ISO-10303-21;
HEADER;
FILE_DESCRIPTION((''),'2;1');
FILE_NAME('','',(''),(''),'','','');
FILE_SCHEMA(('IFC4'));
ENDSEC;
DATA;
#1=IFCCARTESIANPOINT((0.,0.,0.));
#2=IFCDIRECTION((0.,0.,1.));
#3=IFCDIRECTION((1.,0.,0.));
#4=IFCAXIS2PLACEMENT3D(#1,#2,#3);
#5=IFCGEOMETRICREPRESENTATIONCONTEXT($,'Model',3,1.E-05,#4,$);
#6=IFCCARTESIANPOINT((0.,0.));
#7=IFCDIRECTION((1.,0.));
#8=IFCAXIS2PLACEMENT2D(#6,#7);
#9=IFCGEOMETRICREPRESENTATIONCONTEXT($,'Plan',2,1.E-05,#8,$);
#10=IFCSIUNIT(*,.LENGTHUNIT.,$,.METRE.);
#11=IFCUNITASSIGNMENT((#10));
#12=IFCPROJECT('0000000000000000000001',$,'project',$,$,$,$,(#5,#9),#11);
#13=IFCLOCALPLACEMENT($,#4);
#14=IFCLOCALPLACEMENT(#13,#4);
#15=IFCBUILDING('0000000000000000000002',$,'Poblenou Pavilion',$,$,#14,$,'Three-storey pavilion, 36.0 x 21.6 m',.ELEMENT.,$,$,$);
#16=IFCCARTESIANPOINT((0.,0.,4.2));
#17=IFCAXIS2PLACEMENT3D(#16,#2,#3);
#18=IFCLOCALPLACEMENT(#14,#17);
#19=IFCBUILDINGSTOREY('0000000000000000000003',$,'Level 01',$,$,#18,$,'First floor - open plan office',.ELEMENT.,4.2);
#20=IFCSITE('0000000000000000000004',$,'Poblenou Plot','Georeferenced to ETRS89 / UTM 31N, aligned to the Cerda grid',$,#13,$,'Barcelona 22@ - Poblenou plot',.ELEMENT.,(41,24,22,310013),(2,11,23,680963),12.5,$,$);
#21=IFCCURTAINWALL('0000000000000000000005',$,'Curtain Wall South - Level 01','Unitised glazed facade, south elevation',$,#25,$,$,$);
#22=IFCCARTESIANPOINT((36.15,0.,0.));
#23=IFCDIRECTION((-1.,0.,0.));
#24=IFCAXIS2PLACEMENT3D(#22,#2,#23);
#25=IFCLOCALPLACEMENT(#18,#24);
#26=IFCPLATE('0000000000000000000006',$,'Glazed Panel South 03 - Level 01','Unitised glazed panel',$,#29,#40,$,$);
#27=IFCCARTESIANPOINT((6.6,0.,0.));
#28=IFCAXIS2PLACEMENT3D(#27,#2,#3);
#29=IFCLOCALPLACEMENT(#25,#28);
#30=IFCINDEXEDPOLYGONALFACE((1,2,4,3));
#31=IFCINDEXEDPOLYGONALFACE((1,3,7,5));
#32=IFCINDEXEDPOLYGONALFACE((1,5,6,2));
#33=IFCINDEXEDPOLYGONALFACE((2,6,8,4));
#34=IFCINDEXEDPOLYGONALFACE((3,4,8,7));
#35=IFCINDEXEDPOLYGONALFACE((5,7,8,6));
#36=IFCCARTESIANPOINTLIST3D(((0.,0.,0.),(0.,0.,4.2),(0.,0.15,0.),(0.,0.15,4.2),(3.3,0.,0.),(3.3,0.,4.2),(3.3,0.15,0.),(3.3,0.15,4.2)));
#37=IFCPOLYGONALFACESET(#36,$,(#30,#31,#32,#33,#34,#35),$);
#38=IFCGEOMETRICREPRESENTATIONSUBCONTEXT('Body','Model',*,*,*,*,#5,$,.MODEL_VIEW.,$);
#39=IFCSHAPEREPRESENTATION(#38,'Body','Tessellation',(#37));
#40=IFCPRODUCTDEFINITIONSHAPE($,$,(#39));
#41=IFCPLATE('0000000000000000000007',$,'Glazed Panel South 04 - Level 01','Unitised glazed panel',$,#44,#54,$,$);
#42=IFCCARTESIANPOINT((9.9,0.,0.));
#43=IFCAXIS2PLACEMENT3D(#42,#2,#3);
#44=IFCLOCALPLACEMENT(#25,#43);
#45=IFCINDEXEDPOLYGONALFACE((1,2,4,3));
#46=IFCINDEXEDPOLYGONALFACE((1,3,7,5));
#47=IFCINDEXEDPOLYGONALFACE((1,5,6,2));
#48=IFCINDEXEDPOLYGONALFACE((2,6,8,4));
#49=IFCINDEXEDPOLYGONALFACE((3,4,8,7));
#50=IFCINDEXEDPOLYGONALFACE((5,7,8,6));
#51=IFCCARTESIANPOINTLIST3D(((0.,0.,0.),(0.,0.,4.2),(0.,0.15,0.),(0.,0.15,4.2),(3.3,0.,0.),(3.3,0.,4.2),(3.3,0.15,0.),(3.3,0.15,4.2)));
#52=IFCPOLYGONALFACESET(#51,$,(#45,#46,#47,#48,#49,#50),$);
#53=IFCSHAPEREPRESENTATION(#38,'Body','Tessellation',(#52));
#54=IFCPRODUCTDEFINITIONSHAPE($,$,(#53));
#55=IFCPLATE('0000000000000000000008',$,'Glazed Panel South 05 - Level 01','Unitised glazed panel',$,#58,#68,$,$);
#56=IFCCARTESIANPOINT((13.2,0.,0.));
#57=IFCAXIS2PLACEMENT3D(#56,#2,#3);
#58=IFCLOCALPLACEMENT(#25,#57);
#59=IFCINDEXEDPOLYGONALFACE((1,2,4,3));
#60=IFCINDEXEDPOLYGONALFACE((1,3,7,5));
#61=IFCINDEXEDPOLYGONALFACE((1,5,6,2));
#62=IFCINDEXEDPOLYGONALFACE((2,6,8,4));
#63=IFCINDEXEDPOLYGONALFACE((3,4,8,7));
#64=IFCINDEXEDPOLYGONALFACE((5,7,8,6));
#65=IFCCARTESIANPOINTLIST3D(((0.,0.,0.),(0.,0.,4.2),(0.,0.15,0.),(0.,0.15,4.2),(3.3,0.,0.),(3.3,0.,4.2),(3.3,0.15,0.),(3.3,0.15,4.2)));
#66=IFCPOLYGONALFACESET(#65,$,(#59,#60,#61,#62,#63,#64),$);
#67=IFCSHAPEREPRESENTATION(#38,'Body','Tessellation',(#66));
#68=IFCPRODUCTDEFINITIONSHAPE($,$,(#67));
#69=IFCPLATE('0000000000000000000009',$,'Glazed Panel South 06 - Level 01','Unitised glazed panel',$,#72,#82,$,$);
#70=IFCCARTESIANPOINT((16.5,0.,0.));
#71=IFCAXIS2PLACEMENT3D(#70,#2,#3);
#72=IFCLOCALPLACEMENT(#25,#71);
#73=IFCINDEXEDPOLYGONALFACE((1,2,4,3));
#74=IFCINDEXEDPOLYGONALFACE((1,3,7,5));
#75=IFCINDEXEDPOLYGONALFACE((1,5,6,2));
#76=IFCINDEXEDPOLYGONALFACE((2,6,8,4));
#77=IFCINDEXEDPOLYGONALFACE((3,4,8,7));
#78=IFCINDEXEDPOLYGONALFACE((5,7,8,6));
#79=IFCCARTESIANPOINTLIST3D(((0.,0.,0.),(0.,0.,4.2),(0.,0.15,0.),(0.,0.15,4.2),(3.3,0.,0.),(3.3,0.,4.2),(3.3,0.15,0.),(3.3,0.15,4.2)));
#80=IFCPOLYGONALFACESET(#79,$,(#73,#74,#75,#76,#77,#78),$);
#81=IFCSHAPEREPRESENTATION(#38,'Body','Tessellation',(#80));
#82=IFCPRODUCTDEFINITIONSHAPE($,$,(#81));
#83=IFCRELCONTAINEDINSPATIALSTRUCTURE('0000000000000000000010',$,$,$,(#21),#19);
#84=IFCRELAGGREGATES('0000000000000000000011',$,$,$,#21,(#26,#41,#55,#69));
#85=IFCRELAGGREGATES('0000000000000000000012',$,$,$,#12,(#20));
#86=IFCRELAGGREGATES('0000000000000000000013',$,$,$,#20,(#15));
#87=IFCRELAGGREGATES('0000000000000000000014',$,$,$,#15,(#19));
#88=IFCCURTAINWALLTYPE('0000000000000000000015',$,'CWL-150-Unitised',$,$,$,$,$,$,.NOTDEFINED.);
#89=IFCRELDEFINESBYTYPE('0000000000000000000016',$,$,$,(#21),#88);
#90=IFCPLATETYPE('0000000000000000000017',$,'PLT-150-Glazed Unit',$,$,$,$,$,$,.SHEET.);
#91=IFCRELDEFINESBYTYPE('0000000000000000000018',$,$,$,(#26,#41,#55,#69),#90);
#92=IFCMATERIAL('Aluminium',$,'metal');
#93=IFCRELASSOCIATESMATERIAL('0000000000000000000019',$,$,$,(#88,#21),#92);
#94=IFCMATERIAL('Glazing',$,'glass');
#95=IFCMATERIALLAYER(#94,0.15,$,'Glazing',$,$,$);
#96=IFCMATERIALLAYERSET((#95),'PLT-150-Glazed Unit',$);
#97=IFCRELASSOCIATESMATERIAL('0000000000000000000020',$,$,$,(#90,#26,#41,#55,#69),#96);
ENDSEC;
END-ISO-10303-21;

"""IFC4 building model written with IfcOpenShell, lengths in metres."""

from ifc_helpers import new_model, si_unit, frame, origin_with_axes, origin_2d_with_axis, place, context, subcontext, project, spatial, line, indexed_curve, outline, extrude, material, layer, layer_set, layer_usage, type_object, element, aggregate, save


model = new_model("IFC4")

# Units and contexts
model_context = context("Model", 3, precision=1e-05, world=origin_with_axes())
plan_context = context("Plan", 2, precision=1e-05, world=origin_2d_with_axis())
body_context = subcontext(model_context, "Body", "Model", "MODEL_VIEW")
ifc_project = project(units=[si_unit("LENGTHUNIT", "METRE")], contexts=[model_context, plan_context])

# Site, building, storey
site_placement = place(None, origin_with_axes())
site = spatial("IfcSite", under=ifc_project, at=site_placement, Name="Poblenou Plot", Description="Georeferenced to ETRS89 / UTM 31N, aligned to the Cerda grid", LongName="Barcelona 22@ - Poblenou plot", CompositionType="ELEMENT", RefLatitude=(41, 24, 22, 310013), RefLongitude=(2, 11, 23, 680963), RefElevation=12.5)
building_placement = place(site_placement, origin_with_axes())
building = spatial("IfcBuilding", under=site, at=building_placement, Name="Poblenou Pavilion", LongName="Three-storey pavilion, 36.0 x 21.6 m", CompositionType="ELEMENT")
storey_placement = place(building_placement, frame((0.0, 0.0, 4.2), z_axis=(0.0, 0.0, 1.0), x_axis=(1.0, 0.0, 0.0)))
storey = spatial("IfcBuildingStorey", under=building, at=storey_placement, Name="Level 01", LongName="First floor - open plan office", CompositionType="ELEMENT", Elevation=4.2)

# Curtain wall, plates
ifc_material_1 = material(Name="Aluminium", Category="metal")
curtain_wall_type = type_object("IfcCurtainWallType", Name="CWL-150-Unitised", PredefinedType="NOTDEFINED", material=ifc_material_1)
curtain_wall_1_placement = place(storey_placement, frame((36.15, 0.0, 0.0), z_axis=(0.0, 0.0, 1.0), x_axis=(-1.0, 0.0, 0.0)))
curtain_wall_1 = element("IfcCurtainWall", 1, at=curtain_wall_1_placement, inside=storey, type_object=curtain_wall_type, material=ifc_material_1, Name="Curtain Wall South - Level 01", Description="Unitised glazed facade, south elevation")
ifc_material_2 = material(Name="Glazing", Category="glass")
ifc_layer_1 = layer(ifc_material_2, 0.15, Name="Glazing")
ifc_layer_set_1 = layer_set([ifc_layer_1], Name="PLT-150-Glazed Unit")
plate_type = type_object("IfcPlateType", Name="PLT-150-Glazed Unit", PredefinedType="SHEET", material=ifc_layer_set_1)
ifc_layer_usage_1 = layer_usage(ifc_layer_set_1, "AXIS2", "POSITIVE", 0.0)
plate_1_placement = place(curtain_wall_1_placement, frame((6.6, 0.0, 0.0), z_axis=(0.0, 0.0, 1.0), x_axis=(1.0, 0.0, 0.0)))
plate_1 = element("IfcPlate", 2, at=plate_1_placement, type_object=plate_type, material=ifc_layer_usage_1, Name="Glazed Panel South 03 - Level 01", Description="Unitised glazed panel", context=body_context, shape_type="SweptSolid", body=[
    extrude(outline(indexed_curve([(0.0, 0.0), (3.3, 0.0), (3.3, 0.15), (0.0, 0.15)], segments=[line(1, 2, 3, 4, 1)])), origin_with_axes(), (0.0, 0.0, 1.0), 4.2),
])
ifc_layer_usage_2 = layer_usage(ifc_layer_set_1, "AXIS2", "POSITIVE", 0.0)
plate_2_placement = place(curtain_wall_1_placement, frame((9.9, 0.0, 0.0), z_axis=(0.0, 0.0, 1.0), x_axis=(1.0, 0.0, 0.0)))
plate_2 = element("IfcPlate", 3, at=plate_2_placement, type_object=plate_type, material=ifc_layer_usage_2, Name="Glazed Panel South 04 - Level 01", Description="Unitised glazed panel", context=body_context, shape_type="SweptSolid", body=[
    extrude(outline(indexed_curve([(0.0, 0.0), (3.3, 0.0), (3.3, 0.15), (0.0, 0.15)], segments=[line(1, 2, 3, 4, 1)])), origin_with_axes(), (0.0, 0.0, 1.0), 4.2),
])
ifc_layer_usage_3 = layer_usage(ifc_layer_set_1, "AXIS2", "POSITIVE", 0.0)
plate_3_placement = place(curtain_wall_1_placement, frame((13.2, 0.0, 0.0), z_axis=(0.0, 0.0, 1.0), x_axis=(1.0, 0.0, 0.0)))
plate_3 = element("IfcPlate", 4, at=plate_3_placement, type_object=plate_type, material=ifc_layer_usage_3, Name="Glazed Panel South 05 - Level 01", Description="Unitised glazed panel", context=body_context, shape_type="SweptSolid", body=[
    extrude(outline(indexed_curve([(0.0, 0.0), (3.3, 0.0), (3.3, 0.15), (0.0, 0.15)], segments=[line(1, 2, 3, 4, 1)])), origin_with_axes(), (0.0, 0.0, 1.0), 4.2),
])
ifc_layer_usage_4 = layer_usage(ifc_layer_set_1, "AXIS2", "POSITIVE", 0.0)
plate_4_placement = place(curtain_wall_1_placement, frame((16.5, 0.0, 0.0), z_axis=(0.0, 0.0, 1.0), x_axis=(1.0, 0.0, 0.0)))
plate_4 = element("IfcPlate", 5, at=plate_4_placement, type_object=plate_type, material=ifc_layer_usage_4, Name="Glazed Panel South 06 - Level 01", Description="Unitised glazed panel", context=body_context, shape_type="SweptSolid", body=[
    extrude(outline(indexed_curve([(0.0, 0.0), (3.3, 0.0), (3.3, 0.15), (0.0, 0.15)], segments=[line(1, 2, 3, 4, 1)])), origin_with_axes(), (0.0, 0.0, 1.0), 4.2),
])
aggregate(curtain_wall_1, [plate_1, plate_2, plate_3, plate_4])

save(model, "model.ifc")
